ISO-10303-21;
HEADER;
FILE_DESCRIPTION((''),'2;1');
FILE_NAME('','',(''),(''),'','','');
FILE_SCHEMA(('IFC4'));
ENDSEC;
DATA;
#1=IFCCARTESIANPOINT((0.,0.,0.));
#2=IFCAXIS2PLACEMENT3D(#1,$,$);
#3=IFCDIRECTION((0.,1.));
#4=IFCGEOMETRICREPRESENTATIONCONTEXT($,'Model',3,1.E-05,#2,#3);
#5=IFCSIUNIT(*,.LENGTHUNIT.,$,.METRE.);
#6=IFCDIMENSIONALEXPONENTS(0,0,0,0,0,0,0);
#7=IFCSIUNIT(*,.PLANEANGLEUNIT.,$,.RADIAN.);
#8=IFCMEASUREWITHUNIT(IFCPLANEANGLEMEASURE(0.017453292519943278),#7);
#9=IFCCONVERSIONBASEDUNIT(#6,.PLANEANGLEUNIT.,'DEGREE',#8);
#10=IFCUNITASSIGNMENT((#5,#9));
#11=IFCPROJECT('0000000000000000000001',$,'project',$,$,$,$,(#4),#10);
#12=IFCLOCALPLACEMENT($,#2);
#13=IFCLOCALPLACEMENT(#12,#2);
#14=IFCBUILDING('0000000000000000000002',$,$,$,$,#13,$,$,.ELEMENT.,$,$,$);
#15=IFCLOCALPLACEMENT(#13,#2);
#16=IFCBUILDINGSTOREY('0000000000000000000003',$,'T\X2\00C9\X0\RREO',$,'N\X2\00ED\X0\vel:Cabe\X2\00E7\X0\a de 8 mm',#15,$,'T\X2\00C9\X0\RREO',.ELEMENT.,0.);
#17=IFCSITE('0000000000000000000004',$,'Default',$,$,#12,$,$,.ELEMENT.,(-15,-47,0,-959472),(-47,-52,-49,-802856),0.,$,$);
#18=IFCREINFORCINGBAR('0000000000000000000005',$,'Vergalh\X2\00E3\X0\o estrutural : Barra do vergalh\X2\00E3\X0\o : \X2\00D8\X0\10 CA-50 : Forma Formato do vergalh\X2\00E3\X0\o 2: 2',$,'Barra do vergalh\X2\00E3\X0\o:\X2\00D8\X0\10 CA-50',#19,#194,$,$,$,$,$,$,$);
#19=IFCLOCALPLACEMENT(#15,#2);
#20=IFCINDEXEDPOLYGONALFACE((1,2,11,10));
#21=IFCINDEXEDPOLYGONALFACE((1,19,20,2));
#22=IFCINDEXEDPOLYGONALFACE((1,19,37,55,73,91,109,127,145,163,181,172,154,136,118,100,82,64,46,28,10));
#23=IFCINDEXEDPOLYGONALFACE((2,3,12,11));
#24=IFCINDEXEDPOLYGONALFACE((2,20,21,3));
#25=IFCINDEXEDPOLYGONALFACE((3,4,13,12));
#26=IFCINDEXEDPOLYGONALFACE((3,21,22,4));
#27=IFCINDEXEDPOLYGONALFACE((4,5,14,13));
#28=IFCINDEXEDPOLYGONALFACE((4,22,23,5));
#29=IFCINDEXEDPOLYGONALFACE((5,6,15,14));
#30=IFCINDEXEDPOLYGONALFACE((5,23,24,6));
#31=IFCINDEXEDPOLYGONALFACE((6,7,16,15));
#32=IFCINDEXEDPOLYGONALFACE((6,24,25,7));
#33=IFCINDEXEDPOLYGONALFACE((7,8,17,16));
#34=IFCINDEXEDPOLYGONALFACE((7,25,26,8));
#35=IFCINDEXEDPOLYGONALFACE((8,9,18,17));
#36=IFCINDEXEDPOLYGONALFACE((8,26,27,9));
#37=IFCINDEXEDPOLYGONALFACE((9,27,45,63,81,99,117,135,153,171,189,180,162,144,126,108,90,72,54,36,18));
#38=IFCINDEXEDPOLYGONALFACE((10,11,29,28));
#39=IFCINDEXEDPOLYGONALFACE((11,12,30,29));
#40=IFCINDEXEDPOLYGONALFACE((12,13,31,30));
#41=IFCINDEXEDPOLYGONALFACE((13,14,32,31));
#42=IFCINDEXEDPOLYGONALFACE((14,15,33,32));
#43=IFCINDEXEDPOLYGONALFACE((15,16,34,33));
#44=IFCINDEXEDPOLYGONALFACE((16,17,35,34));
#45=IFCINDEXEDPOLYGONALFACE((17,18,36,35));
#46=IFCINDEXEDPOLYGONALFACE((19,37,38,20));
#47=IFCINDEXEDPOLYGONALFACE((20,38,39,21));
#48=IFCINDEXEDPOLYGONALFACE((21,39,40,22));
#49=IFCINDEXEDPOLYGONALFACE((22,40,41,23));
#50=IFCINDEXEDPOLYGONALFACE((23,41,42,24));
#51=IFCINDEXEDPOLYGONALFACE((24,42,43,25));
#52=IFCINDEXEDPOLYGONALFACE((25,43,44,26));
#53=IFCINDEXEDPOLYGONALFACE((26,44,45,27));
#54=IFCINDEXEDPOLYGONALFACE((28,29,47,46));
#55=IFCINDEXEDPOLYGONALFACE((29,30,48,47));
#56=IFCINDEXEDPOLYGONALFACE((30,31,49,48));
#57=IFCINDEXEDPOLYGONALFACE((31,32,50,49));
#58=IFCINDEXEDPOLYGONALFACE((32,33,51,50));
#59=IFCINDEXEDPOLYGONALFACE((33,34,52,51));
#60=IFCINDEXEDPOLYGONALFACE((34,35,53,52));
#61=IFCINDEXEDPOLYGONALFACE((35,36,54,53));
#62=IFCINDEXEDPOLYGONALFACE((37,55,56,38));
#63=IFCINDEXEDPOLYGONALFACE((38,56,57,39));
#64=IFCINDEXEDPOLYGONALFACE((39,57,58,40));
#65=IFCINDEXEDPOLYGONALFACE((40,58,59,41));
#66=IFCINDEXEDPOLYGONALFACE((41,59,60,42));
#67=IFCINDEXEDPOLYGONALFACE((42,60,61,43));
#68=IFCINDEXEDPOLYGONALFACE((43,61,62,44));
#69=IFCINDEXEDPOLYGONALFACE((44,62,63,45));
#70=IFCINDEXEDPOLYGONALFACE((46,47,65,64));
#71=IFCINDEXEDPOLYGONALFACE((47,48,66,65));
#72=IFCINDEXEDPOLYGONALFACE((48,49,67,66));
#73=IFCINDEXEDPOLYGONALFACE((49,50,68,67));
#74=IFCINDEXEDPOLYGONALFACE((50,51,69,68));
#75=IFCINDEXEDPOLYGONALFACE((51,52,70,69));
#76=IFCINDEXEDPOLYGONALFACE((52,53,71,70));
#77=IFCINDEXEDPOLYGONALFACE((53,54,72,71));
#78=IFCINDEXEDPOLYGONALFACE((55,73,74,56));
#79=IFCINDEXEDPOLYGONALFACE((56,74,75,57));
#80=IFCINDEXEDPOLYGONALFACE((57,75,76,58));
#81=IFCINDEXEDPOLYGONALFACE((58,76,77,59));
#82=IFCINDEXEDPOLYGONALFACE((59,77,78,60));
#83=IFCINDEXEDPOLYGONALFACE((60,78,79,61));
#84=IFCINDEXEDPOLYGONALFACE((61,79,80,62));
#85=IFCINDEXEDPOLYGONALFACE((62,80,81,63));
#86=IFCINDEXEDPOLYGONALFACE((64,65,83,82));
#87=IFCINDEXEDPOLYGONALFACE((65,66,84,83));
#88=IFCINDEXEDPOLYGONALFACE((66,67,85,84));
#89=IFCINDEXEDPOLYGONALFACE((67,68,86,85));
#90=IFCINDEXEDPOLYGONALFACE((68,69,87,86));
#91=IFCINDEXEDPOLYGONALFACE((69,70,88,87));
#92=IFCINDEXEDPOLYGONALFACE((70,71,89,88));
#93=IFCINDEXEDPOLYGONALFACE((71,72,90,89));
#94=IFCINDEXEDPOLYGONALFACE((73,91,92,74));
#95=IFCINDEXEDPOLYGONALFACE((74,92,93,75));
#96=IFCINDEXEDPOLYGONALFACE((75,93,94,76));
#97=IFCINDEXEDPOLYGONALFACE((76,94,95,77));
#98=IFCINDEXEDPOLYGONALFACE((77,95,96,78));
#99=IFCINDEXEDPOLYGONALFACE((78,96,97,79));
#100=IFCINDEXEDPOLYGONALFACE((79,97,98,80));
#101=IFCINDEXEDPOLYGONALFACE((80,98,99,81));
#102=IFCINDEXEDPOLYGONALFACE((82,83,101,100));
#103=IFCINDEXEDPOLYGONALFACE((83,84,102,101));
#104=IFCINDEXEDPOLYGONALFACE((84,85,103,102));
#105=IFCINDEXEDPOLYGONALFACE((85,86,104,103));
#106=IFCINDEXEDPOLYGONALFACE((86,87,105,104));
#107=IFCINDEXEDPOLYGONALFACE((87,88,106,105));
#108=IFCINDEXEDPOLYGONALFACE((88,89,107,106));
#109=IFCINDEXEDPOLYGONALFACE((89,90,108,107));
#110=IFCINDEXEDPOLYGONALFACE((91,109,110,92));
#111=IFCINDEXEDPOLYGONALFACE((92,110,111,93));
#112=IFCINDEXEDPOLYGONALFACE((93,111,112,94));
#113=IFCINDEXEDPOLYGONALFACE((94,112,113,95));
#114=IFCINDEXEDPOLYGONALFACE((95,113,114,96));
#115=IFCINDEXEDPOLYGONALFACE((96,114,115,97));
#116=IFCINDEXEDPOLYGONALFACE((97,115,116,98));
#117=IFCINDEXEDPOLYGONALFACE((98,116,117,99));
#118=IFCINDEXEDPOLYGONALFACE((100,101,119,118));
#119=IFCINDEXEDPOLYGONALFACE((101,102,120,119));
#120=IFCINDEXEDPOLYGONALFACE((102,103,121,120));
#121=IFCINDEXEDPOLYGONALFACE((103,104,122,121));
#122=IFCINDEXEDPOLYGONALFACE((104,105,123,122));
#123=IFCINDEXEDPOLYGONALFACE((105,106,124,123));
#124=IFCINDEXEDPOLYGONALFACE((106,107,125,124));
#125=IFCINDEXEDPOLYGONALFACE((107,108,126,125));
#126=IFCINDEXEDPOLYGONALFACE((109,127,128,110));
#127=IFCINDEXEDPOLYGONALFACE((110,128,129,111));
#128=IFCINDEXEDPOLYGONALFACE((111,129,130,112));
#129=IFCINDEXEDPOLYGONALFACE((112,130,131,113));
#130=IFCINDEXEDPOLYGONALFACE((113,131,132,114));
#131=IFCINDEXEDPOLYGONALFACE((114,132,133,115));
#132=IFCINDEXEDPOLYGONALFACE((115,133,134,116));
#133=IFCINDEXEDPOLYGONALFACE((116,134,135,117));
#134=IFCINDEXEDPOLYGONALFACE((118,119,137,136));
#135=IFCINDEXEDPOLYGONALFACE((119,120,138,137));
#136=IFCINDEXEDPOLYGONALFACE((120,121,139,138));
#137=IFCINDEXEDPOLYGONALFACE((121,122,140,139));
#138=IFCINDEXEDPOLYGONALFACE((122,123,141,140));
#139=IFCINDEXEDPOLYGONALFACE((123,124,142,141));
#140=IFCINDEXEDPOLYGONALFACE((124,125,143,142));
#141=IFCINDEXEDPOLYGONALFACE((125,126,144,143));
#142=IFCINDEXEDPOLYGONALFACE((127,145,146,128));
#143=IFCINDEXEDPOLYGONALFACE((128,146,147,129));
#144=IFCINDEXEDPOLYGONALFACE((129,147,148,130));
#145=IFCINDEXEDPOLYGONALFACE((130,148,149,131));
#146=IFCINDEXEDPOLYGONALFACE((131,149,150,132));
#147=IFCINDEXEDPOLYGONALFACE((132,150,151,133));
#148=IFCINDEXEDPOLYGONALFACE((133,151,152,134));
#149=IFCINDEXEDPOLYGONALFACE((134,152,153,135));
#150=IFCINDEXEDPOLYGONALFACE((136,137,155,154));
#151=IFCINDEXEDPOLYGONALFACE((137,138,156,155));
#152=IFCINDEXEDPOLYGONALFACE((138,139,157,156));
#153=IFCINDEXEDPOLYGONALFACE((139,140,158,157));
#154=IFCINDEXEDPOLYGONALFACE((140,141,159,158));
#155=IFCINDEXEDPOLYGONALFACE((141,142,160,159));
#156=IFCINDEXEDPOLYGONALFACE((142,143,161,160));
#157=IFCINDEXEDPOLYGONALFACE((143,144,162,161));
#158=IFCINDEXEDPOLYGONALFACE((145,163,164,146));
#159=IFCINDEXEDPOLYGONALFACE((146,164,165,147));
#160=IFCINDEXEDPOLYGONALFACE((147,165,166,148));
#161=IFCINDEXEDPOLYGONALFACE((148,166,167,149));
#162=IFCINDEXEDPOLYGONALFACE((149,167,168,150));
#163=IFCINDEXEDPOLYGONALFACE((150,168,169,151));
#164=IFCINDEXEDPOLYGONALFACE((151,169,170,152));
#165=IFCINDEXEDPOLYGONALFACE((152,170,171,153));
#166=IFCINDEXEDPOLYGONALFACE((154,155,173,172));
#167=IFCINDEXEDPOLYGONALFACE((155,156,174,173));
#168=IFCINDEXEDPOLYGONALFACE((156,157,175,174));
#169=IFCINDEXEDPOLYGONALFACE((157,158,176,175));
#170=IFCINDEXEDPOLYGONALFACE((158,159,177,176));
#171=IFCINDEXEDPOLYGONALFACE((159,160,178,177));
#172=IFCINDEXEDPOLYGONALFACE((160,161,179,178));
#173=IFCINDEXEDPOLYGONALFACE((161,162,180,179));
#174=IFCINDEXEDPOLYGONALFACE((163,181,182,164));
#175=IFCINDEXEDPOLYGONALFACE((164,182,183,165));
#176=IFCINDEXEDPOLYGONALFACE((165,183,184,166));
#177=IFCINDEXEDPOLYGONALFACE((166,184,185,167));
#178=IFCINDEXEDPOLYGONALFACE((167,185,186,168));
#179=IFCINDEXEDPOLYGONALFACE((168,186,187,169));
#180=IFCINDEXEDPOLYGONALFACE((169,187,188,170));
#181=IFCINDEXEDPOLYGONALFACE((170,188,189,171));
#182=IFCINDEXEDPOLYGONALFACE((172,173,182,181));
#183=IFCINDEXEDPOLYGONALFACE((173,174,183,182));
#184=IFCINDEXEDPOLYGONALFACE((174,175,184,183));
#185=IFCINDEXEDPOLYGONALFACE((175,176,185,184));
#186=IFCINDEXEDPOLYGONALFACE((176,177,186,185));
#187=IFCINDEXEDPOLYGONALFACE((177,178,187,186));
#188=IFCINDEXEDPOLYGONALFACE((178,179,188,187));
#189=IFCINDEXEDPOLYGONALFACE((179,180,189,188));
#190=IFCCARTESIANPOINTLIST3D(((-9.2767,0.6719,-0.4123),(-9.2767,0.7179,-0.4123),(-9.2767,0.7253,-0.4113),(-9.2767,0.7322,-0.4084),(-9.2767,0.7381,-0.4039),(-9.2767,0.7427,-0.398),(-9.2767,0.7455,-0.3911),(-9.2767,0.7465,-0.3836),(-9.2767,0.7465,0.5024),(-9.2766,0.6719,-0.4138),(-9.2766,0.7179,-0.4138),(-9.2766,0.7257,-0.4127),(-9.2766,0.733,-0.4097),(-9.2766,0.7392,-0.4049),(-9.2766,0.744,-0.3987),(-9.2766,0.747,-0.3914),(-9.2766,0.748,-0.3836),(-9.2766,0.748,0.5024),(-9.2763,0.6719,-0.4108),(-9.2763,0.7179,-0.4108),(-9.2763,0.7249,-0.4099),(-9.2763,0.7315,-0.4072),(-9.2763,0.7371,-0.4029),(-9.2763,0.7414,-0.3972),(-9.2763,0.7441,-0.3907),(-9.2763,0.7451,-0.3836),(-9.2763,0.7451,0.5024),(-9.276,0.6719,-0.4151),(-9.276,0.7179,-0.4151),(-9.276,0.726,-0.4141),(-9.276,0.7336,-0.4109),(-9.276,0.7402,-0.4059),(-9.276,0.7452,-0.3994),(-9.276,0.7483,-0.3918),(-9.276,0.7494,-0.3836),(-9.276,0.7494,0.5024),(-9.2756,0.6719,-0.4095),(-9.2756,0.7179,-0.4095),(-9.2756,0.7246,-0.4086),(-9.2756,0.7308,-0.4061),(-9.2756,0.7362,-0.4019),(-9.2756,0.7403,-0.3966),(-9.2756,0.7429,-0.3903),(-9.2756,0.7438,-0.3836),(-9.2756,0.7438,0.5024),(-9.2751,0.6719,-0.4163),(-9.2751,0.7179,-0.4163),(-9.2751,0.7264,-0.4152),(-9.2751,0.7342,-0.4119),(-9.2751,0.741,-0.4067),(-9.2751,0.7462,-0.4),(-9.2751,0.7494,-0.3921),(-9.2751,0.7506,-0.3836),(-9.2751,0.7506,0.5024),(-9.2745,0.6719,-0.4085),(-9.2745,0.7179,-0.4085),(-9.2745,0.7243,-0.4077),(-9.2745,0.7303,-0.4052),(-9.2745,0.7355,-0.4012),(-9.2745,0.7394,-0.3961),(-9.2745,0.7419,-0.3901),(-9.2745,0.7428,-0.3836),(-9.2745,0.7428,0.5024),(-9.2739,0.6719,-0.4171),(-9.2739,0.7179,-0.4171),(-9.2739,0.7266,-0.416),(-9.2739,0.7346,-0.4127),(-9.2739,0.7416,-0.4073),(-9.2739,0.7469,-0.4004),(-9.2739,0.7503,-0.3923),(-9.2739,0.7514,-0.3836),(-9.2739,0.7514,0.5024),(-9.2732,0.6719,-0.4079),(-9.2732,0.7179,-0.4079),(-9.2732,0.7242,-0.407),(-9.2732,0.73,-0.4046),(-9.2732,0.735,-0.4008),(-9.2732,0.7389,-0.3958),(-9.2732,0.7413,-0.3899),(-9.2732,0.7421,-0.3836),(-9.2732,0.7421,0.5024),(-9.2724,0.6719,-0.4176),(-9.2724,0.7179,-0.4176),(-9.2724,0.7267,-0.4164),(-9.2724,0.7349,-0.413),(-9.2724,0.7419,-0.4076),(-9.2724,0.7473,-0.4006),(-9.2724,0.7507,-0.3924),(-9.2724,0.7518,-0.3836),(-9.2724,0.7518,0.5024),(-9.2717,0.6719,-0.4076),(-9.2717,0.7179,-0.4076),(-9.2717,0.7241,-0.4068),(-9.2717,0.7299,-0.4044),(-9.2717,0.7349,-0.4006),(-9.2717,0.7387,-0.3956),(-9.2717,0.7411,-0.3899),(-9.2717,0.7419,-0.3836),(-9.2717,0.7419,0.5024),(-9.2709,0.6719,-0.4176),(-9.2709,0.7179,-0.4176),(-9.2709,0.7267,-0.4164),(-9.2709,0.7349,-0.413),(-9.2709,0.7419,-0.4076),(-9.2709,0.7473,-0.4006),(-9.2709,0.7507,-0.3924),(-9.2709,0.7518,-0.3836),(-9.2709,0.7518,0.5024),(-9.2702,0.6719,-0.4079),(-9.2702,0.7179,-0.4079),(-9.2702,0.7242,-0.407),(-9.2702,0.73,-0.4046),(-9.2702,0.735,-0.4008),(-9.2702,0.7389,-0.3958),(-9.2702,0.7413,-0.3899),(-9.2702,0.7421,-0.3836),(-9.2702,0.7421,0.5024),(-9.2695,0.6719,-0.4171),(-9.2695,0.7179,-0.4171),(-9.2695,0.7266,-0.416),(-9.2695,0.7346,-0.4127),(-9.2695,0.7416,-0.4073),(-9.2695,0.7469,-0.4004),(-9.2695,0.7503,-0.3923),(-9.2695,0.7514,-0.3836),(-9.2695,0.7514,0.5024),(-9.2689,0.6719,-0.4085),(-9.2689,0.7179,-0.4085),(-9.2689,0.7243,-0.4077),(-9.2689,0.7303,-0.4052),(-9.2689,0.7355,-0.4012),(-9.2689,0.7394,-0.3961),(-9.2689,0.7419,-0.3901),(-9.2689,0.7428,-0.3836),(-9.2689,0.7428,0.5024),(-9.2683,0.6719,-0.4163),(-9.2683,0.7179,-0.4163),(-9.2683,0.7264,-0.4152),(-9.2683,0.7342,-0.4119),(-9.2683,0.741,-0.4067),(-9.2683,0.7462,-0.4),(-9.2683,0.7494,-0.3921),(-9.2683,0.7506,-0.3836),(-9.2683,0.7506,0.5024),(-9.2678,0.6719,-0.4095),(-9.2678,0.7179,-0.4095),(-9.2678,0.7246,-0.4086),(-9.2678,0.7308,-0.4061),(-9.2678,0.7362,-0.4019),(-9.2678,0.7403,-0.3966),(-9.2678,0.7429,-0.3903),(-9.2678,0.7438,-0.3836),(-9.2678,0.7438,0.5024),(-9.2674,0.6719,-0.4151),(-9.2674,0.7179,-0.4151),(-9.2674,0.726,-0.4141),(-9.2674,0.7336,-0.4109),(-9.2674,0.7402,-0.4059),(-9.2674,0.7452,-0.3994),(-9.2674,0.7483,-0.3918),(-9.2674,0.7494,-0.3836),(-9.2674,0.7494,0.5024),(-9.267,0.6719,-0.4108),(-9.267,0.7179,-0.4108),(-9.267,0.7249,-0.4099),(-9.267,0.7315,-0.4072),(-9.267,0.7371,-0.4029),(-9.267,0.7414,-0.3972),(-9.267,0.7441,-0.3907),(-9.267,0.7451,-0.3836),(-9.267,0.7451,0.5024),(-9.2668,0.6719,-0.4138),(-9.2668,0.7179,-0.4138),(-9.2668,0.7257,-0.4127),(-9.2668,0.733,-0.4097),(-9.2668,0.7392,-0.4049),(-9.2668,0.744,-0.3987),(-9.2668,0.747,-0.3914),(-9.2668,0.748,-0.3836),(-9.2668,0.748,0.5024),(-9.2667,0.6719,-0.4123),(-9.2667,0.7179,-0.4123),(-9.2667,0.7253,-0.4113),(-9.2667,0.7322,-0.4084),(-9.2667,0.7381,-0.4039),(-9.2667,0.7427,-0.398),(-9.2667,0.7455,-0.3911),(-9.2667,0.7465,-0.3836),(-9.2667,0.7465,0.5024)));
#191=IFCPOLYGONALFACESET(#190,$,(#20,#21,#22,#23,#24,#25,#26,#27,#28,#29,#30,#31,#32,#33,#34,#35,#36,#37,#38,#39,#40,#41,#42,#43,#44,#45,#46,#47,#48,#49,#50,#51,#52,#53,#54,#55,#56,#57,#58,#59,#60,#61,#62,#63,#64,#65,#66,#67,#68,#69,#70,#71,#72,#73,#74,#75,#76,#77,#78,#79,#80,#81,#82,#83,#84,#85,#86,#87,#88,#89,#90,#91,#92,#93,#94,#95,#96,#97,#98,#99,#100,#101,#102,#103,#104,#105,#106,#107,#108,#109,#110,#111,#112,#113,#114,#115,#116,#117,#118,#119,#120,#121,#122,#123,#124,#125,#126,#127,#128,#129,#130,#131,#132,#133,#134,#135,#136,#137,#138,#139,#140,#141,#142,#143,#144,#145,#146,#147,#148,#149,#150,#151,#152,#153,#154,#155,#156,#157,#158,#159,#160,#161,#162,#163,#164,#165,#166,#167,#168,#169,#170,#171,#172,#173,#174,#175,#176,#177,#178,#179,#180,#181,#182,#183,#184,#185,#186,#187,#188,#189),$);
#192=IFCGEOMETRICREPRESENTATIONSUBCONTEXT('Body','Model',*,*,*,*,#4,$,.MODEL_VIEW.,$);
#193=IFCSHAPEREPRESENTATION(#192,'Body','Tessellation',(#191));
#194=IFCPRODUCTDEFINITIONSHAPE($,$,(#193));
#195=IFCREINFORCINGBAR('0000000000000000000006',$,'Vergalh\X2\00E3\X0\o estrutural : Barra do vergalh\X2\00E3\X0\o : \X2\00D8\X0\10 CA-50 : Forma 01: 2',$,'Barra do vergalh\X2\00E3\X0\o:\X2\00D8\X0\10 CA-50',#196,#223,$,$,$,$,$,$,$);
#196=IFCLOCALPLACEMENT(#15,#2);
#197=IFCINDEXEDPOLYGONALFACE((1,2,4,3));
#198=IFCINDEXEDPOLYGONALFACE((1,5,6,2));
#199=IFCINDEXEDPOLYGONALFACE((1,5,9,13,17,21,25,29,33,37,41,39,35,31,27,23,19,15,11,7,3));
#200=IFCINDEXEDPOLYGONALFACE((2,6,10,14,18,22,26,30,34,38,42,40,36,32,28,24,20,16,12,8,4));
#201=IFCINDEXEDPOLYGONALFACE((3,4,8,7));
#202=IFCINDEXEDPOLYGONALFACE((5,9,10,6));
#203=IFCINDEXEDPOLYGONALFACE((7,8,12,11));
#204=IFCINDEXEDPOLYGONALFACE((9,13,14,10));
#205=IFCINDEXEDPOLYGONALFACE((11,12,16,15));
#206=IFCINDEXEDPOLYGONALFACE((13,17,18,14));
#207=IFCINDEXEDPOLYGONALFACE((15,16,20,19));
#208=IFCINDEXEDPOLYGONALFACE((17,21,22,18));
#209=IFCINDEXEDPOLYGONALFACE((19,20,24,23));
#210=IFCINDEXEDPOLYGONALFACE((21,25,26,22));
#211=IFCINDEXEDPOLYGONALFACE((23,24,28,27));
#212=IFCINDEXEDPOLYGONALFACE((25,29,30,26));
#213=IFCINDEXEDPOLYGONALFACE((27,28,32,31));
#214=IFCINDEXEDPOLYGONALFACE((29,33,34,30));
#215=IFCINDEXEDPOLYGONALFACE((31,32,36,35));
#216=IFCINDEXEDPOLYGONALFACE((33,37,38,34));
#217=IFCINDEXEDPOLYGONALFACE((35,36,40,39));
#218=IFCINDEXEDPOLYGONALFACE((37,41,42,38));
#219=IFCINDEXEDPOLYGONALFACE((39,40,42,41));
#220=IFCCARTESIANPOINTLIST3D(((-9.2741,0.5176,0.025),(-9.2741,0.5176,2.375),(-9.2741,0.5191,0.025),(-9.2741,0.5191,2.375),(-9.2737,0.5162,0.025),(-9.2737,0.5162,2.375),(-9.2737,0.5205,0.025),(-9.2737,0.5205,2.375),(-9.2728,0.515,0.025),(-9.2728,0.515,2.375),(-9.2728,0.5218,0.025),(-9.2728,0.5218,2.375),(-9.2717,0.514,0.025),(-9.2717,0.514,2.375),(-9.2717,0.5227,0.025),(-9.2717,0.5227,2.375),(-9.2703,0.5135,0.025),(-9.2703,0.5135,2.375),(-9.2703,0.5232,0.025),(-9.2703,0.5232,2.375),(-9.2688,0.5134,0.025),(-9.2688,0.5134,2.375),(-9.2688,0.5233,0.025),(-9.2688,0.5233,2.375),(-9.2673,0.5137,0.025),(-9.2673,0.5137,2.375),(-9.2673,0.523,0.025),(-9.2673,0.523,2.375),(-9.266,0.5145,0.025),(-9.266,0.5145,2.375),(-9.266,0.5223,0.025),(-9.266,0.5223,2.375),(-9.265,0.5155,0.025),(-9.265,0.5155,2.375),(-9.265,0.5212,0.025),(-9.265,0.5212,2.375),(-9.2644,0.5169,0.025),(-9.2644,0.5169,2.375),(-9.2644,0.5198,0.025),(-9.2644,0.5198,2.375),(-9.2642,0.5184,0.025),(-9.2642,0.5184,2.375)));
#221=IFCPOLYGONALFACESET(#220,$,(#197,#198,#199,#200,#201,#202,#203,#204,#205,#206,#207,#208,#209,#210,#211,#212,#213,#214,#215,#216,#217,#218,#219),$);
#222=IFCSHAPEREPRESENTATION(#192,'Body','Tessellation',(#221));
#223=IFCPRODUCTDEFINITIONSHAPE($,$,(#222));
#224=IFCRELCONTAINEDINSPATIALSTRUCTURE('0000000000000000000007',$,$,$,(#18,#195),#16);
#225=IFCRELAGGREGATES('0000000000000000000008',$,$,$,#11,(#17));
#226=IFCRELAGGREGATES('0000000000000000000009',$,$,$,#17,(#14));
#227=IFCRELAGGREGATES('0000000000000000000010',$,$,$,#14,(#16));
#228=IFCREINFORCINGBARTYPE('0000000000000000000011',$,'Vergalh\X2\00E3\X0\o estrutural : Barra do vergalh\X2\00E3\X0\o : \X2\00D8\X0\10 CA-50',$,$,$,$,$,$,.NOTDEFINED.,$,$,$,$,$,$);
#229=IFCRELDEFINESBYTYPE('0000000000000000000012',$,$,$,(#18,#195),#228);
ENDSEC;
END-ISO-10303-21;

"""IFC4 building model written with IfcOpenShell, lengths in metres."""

from ifc_helpers import new_model, entity, si_unit, converted_unit, direction, origin, place, context, subcontext, project, spatial, type_object, element, save


model = new_model("IFC4")

# Units and contexts
model_context = context("Model", 3, precision=1e-05, world=origin(), true_north=direction((0.0, 1.0)))
body_context = subcontext(model_context, "Body", "Model", "MODEL_VIEW")
ifc_project = project(units=[si_unit("LENGTHUNIT", "METRE"), converted_unit("PLANEANGLEUNIT", "DEGREE", entity("IfcPlaneAngleMeasure", 0.017453292519943278), si_unit("PLANEANGLEUNIT", "RADIAN"), dimensions=[0, 0, 0, 0, 0, 0, 0])], contexts=[model_context])

# Site, building, storey
site_placement = place(None, origin())
site = spatial("IfcSite", under=ifc_project, at=site_placement, Name="Default", CompositionType="ELEMENT", RefLatitude=(-15, -47, 0, -959472), RefLongitude=(-47, -52, -49, -802856), RefElevation=0.0)
building_placement = place(site_placement, origin())
building = spatial("IfcBuilding", under=site, at=building_placement, CompositionType="ELEMENT")
storey_placement = place(building_placement, origin())
storey = spatial("IfcBuildingStorey", under=building, at=storey_placement, Name="TÉRREO", ObjectType="Nível:Cabeça de 8 mm", LongName="TÉRREO", CompositionType="ELEMENT", Elevation=0.0)

# Reinforcing bars
reinforcing_bar_type_1 = type_object("IfcReinforcingBarType", Name="Vergalhão estrutural : Barra do vergalhão : Ø10 CA-50", PredefinedType="NOTDEFINED")
reinforcing_bar_1_placement = place(storey_placement, origin())
element("IfcReinforcingBar", 1, at=reinforcing_bar_1_placement, inside=storey, type_object=reinforcing_bar_type_1, Name="Vergalhão estrutural : Barra do vergalhão : Ø10 CA-50 : Forma Formato do vergalhão 2: 2", ObjectType="Barra do vergalhão:Ø10 CA-50", context=body_context, shape_type="AdvancedSweptSolid", body=[
    entity("IfcSweptDiskSolid", entity("IfcIndexedPolyCurve", entity("IfcCartesianPointList3D", [[-9.2717, 0.6719, -0.4126], [-9.2717, 0.7179, -0.4126], [-9.2717, 0.7384, -0.4042], [-9.2717, 0.7469, -0.3836], [-9.2717, 0.7469, 0.5024]]), [entity("IfcLineIndex", [1, 2]), entity("IfcArcIndex", [2, 3, 4]), entity("IfcLineIndex", [4, 5])], False), 0.005, None, 0.0, 92.0),
])
reinforcing_bar_2_placement = place(storey_placement, origin())
element("IfcReinforcingBar", 2, at=reinforcing_bar_2_placement, inside=storey, type_object=reinforcing_bar_type_1, Name="Vergalhão estrutural : Barra do vergalhão : Ø10 CA-50 : Forma 01: 2", ObjectType="Barra do vergalhão:Ø10 CA-50", context=body_context, shape_type="AdvancedSweptSolid", body=[
    entity("IfcSweptDiskSolid", entity("IfcIndexedPolyCurve", entity("IfcCartesianPointList3D", [[-9.2692, 0.5184, 0.025], [-9.2692, 0.5184, 2.375]]), None, False), 0.005, None, 0.0, 1.0),
])

save(model, "model.ifc")
